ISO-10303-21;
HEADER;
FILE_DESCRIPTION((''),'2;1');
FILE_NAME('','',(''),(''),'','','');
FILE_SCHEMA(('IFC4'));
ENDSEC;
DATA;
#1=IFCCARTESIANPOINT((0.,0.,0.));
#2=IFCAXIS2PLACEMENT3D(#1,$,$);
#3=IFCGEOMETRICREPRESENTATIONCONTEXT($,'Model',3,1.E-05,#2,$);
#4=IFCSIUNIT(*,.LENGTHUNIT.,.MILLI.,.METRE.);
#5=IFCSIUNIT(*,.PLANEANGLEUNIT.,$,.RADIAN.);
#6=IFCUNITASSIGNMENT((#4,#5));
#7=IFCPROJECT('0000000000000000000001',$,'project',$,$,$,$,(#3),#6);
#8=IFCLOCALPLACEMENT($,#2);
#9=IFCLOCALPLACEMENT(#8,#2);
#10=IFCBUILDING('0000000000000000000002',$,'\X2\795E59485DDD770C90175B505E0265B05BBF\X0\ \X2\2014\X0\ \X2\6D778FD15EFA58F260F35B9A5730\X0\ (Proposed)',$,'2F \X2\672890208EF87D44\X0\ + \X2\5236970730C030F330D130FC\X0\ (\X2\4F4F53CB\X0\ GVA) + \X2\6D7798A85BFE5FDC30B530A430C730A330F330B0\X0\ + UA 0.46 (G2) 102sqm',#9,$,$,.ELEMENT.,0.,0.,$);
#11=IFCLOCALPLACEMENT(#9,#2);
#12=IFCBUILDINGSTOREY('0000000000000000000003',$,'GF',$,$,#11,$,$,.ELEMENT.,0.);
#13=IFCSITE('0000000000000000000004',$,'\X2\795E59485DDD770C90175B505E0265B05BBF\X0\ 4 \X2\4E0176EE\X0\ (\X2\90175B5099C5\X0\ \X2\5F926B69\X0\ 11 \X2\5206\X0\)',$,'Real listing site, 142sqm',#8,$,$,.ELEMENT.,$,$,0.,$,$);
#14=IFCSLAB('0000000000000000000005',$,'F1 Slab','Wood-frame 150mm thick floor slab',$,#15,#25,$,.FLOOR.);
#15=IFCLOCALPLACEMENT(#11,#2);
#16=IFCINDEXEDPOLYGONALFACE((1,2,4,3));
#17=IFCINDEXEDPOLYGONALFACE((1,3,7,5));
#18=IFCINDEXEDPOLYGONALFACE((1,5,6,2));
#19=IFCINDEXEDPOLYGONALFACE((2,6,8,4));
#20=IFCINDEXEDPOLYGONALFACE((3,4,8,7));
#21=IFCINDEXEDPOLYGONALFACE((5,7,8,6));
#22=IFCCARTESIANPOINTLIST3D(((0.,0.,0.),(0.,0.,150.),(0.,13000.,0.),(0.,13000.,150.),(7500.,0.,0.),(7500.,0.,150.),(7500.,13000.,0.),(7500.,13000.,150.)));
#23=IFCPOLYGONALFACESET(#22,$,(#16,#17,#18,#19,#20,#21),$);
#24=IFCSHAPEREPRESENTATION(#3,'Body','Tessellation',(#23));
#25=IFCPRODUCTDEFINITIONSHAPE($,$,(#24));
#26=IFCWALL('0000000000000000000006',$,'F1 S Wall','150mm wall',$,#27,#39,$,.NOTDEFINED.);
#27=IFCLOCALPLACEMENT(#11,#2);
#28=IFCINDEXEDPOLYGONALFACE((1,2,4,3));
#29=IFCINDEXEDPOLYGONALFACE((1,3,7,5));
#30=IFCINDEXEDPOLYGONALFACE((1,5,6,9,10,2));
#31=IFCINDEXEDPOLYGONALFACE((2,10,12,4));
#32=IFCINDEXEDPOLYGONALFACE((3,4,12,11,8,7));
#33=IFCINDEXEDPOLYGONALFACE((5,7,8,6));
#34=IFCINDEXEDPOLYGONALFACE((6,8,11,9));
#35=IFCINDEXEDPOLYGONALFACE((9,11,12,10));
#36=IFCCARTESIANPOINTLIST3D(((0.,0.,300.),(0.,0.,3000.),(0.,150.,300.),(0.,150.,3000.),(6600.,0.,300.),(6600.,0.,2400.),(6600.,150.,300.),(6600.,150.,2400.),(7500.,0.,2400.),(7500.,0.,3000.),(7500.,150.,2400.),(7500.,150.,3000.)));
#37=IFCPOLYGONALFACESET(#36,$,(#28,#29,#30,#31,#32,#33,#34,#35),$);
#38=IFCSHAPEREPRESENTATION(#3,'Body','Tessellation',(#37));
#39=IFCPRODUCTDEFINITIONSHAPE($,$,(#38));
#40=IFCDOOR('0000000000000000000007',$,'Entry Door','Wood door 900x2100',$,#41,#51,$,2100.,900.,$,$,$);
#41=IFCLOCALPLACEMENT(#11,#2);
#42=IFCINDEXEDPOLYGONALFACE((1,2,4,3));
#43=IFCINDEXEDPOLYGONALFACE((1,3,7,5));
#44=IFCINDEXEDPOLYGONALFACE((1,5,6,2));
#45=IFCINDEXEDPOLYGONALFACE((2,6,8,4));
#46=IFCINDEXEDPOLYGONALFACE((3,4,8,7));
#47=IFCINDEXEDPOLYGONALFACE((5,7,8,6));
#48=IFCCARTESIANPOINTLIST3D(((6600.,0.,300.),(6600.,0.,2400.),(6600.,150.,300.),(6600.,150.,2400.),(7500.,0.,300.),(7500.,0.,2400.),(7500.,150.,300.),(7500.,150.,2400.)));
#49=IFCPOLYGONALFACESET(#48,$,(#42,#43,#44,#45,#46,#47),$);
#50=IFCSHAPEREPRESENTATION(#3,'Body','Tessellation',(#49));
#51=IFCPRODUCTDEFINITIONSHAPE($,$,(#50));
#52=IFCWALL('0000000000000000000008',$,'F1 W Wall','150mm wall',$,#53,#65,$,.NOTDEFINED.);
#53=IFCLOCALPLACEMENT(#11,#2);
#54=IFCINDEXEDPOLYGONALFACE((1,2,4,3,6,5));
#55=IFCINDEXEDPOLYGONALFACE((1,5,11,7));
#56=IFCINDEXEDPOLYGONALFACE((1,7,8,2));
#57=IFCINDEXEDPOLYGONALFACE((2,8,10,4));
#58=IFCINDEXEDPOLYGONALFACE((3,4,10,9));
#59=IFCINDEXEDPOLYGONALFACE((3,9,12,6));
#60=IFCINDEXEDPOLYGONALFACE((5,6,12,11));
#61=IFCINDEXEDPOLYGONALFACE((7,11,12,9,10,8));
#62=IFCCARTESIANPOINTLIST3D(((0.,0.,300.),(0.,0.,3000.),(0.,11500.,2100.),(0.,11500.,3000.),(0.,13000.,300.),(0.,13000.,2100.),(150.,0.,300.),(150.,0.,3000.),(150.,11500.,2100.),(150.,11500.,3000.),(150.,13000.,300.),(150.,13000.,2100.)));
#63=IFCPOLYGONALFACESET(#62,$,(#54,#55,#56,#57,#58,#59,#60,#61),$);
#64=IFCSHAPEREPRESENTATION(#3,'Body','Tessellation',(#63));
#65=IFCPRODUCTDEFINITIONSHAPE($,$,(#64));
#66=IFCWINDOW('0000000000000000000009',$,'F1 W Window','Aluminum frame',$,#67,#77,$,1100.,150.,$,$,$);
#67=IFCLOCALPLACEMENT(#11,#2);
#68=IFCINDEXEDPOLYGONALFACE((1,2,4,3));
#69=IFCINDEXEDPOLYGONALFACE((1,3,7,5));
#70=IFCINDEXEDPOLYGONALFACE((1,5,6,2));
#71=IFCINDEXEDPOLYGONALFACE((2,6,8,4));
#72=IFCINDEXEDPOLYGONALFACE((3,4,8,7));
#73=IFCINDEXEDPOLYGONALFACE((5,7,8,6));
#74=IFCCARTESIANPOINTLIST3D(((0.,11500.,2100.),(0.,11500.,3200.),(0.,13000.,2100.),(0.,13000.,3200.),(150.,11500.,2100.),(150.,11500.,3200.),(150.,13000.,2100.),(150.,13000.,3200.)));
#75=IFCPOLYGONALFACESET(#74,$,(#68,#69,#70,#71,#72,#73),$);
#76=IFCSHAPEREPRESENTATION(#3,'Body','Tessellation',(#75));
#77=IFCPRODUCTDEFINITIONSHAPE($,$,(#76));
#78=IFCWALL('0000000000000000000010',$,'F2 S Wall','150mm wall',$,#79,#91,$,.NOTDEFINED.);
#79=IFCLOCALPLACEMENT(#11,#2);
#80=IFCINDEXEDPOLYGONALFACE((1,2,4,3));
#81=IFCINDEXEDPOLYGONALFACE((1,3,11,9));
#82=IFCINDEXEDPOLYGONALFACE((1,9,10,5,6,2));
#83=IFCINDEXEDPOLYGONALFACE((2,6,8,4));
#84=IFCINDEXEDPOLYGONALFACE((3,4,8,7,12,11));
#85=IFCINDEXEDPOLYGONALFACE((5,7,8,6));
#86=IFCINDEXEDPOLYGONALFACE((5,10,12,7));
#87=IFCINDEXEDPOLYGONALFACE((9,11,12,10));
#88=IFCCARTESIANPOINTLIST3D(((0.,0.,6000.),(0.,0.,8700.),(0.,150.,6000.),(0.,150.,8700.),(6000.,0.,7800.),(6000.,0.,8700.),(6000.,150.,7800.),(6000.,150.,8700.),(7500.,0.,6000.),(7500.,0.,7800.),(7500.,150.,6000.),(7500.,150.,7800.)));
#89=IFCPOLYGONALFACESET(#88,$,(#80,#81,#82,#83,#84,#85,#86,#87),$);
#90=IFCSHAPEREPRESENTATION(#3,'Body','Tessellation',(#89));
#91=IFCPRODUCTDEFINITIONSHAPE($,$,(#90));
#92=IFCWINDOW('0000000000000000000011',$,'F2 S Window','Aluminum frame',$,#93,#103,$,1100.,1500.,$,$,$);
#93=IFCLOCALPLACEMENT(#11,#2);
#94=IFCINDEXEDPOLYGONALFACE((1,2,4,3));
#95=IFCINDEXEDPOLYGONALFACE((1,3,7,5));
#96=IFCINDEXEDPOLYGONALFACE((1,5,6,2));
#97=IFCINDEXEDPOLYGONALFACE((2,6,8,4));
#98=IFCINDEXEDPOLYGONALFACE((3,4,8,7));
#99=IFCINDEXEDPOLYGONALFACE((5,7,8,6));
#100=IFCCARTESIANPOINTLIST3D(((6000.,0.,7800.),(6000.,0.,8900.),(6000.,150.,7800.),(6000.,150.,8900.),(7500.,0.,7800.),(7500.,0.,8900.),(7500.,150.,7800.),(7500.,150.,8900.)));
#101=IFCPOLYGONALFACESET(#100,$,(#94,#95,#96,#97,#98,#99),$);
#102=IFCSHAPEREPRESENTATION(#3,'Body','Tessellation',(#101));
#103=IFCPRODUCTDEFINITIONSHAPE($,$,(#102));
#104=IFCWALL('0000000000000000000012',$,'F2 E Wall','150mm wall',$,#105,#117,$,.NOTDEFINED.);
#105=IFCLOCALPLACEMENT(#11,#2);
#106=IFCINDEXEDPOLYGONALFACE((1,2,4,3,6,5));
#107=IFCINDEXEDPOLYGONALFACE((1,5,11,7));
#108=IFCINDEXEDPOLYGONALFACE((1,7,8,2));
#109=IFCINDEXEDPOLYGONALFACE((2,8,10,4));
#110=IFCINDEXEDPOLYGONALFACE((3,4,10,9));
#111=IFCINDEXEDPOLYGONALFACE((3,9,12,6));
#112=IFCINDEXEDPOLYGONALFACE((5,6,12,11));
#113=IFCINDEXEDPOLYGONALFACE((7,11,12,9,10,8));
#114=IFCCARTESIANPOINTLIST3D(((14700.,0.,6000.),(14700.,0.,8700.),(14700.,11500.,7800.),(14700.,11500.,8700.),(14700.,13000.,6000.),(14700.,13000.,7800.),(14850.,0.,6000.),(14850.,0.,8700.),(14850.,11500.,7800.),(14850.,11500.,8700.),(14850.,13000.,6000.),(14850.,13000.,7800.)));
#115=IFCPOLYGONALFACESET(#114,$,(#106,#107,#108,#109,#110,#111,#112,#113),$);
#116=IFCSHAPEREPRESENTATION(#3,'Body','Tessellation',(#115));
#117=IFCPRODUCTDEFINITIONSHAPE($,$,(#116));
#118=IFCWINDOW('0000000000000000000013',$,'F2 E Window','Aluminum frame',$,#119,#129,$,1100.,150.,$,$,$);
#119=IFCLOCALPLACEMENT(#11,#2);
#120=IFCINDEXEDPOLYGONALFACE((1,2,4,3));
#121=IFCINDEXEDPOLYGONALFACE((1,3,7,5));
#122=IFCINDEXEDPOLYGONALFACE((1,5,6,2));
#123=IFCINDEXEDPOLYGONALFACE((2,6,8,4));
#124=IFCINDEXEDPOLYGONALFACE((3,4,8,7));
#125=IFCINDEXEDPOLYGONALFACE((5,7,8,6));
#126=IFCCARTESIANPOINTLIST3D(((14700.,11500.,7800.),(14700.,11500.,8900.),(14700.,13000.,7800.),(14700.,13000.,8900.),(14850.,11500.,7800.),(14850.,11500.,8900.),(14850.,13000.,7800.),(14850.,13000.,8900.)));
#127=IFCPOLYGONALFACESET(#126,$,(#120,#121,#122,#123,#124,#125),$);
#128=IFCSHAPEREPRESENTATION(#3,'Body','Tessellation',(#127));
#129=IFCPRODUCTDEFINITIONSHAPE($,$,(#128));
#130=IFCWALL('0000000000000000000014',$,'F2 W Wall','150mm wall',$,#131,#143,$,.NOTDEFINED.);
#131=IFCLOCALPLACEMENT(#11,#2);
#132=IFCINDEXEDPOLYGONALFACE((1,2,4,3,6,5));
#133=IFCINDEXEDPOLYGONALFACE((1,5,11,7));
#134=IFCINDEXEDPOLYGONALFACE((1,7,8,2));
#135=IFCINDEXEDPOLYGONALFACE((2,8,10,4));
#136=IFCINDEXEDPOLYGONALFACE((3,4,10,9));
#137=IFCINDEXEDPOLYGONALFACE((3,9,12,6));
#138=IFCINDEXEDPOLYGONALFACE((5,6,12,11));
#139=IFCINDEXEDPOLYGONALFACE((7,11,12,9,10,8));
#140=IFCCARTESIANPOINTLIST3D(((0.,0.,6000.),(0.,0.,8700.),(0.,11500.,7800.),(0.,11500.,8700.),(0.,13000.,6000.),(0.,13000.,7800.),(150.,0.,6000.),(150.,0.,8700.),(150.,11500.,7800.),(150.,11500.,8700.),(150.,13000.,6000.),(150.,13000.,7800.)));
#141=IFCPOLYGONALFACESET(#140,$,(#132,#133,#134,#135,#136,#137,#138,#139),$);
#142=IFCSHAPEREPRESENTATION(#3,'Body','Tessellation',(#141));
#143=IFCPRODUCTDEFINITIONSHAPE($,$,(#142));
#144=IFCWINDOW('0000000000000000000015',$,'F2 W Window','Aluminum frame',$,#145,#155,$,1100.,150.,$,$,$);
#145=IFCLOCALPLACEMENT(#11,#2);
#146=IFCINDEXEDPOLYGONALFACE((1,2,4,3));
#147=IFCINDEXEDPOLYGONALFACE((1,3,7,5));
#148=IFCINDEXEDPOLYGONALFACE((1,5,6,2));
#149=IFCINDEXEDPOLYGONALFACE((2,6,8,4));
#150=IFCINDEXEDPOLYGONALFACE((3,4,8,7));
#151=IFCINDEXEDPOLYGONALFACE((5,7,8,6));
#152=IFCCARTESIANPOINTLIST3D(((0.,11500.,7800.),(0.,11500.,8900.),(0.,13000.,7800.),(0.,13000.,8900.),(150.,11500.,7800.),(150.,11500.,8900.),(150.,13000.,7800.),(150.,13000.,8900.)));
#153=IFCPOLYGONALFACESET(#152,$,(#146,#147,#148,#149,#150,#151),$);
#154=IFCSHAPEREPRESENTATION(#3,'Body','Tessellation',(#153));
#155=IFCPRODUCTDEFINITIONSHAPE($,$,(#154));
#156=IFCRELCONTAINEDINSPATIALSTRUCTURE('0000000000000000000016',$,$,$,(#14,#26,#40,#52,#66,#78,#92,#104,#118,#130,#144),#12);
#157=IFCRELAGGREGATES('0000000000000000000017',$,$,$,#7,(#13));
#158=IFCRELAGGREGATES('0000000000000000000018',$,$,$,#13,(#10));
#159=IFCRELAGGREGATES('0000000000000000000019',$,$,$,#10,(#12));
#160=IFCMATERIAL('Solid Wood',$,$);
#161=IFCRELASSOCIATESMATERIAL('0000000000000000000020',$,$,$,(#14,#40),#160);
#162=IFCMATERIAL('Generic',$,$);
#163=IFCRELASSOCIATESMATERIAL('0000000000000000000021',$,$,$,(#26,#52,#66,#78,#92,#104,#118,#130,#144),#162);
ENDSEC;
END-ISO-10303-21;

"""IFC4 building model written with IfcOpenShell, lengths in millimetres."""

from ifc_helpers import new_model, si_unit, frame, frame_2d, origin, place, context, project, spatial, rectangle, extrude, material, element, fill, save


model = new_model("IFC4")

# Units and contexts
model_context = context("Model", 3, precision=1e-05, world=origin())
ifc_project = project(units=[si_unit("LENGTHUNIT", "METRE", prefix="MILLI"), si_unit("PLANEANGLEUNIT", "RADIAN")], contexts=[model_context])

# Site, building, storey
site_placement = place(None, origin())
site = spatial("IfcSite", under=ifc_project, at=site_placement, Name="神奈川県逗子市新宿 4 丁目 (逗子駅 徒歩 11 分)", ObjectType="Real listing site, 142sqm", CompositionType="ELEMENT", RefElevation=0.0)
building_placement = place(site_placement, origin())
building = spatial("IfcBuilding", under=site, at=building_placement, Name="神奈川県逗子市新宿 — 海近建売想定地 (Proposed)", ObjectType="2F 木造軸組 + 制震ダンパー (住友 GVA) + 海風対応サイディング + UA 0.46 (G2) 102sqm", CompositionType="ELEMENT", ElevationOfRefHeight=0.0, ElevationOfTerrain=0.0)
storey_placement = place(building_placement, origin())
storey = spatial("IfcBuildingStorey", under=building, at=storey_placement, Name="GF", CompositionType="ELEMENT", Elevation=0.0)

# Slab
ifc_material_1 = material(Name="Solid Wood")
slab_1_placement = place(storey_placement, origin())
element("IfcSlab", 1, at=slab_1_placement, inside=storey, material=ifc_material_1, Name="F1 Slab", Description="Wood-frame 150mm thick floor slab", PredefinedType="FLOOR", context=model_context, shape_type="SweptSolid", body=[
    extrude(rectangle(XDim=7500.0, YDim=13000.0, at=frame_2d((3750.0, 6500.0))), origin(), (0.0, 0.0, 1.0), 150.0),
])

# Shared definitions
ifc_material_2 = material(Name="Generic")

# Wall, opening, door
wall_1_placement = place(storey_placement, frame((0.0, 0.0, 150.0)))
wall_1 = element("IfcWall", 2, at=wall_1_placement, inside=storey, material=ifc_material_2, Name="F1 S Wall", Description="150mm wall", PredefinedType="NOTDEFINED", context=model_context, shape_type="SweptSolid", body=[
    extrude(rectangle(XDim=7500.0, YDim=150.0, at=frame_2d((3750.0, 75.0))), frame((0.0, 0.0, 150.0)), (0.0, 0.0, 1.0), 2700.0),
])
opening_1_placement = place(storey_placement, frame((3300.0, 0.0, 150.0)))
opening_1 = element("IfcOpeningElement", 3, at=opening_1_placement, cuts=wall_1, PredefinedType="NOTDEFINED", context=model_context, shape_type="SweptSolid", body=[
    extrude(rectangle(XDim=900.0, YDim=150.0, at=frame_2d((450.0, 75.0))), frame((3300.0, 0.0, 150.0)), (0.0, 0.0, 1.0), 2100.0),
])
door_placement = place(storey_placement, frame((3300.0, 0.0, 150.0)))
door = element("IfcDoor", 4, at=door_placement, inside=storey, material=ifc_material_1, Name="Entry Door", Description="Wood door 900x2100", OverallHeight=2100.0, OverallWidth=900.0, context=model_context, shape_type="SweptSolid", body=[
    extrude(rectangle(XDim=900.0, YDim=150.0, at=frame_2d((450.0, 75.0))), frame((3300.0, 0.0, 150.0)), (0.0, 0.0, 1.0), 2100.0),
])
fill(opening_1, door)

# Walls, openings, windows
wall_2_placement = place(storey_placement, frame((0.0, 0.0, 150.0)))
wall_2 = element("IfcWall", 5, at=wall_2_placement, inside=storey, material=ifc_material_2, Name="F1 W Wall", Description="150mm wall", PredefinedType="NOTDEFINED", context=model_context, shape_type="SweptSolid", body=[
    extrude(rectangle(XDim=150.0, YDim=13000.0, at=frame_2d((75.0, 6500.0))), frame((0.0, 0.0, 150.0)), (0.0, 0.0, 1.0), 2700.0),
])
opening_2_placement = place(storey_placement, frame((0.0, 5750.0, 1050.0)))
opening_2 = element("IfcOpeningElement", 6, at=opening_2_placement, cuts=wall_2, PredefinedType="NOTDEFINED", context=model_context, shape_type="SweptSolid", body=[
    extrude(rectangle(XDim=150.0, YDim=1500.0, at=frame_2d((75.0, 750.0))), frame((0.0, 5750.0, 1050.0)), (0.0, 0.0, 1.0), 1100.0),
])
window_1_placement = place(storey_placement, frame((0.0, 5750.0, 1050.0)))
window_1 = element("IfcWindow", 7, at=window_1_placement, inside=storey, material=ifc_material_2, Name="F1 W Window", Description="Aluminum frame", OverallHeight=1100.0, OverallWidth=150.0, context=model_context, shape_type="SweptSolid", body=[
    extrude(rectangle(XDim=150.0, YDim=1500.0, at=frame_2d((75.0, 750.0))), frame((0.0, 5750.0, 1050.0)), (0.0, 0.0, 1.0), 1100.0),
])
fill(opening_2, window_1)
wall_3_placement = place(storey_placement, frame((0.0, 0.0, 3000.0)))
wall_3 = element("IfcWall", 8, at=wall_3_placement, inside=storey, material=ifc_material_2, Name="F2 S Wall", Description="150mm wall", PredefinedType="NOTDEFINED", context=model_context, shape_type="SweptSolid", body=[
    extrude(rectangle(XDim=7500.0, YDim=150.0, at=frame_2d((3750.0, 75.0))), frame((0.0, 0.0, 3000.0)), (0.0, 0.0, 1.0), 2700.0),
])
opening_3_placement = place(storey_placement, frame((3000.0, 0.0, 3900.0)))
opening_3 = element("IfcOpeningElement", 9, at=opening_3_placement, cuts=wall_3, PredefinedType="NOTDEFINED", context=model_context, shape_type="SweptSolid", body=[
    extrude(rectangle(XDim=1500.0, YDim=150.0, at=frame_2d((750.0, 75.0))), frame((3000.0, 0.0, 3900.0)), (0.0, 0.0, 1.0), 1100.0),
])
window_2_placement = place(storey_placement, frame((3000.0, 0.0, 3900.0)))
window_2 = element("IfcWindow", 10, at=window_2_placement, inside=storey, material=ifc_material_2, Name="F2 S Window", Description="Aluminum frame", OverallHeight=1100.0, OverallWidth=1500.0, context=model_context, shape_type="SweptSolid", body=[
    extrude(rectangle(XDim=1500.0, YDim=150.0, at=frame_2d((750.0, 75.0))), frame((3000.0, 0.0, 3900.0)), (0.0, 0.0, 1.0), 1100.0),
])
fill(opening_3, window_2)
wall_4_placement = place(storey_placement, frame((7350.0, 0.0, 3000.0)))
wall_4 = element("IfcWall", 11, at=wall_4_placement, inside=storey, material=ifc_material_2, Name="F2 E Wall", Description="150mm wall", PredefinedType="NOTDEFINED", context=model_context, shape_type="SweptSolid", body=[
    extrude(rectangle(XDim=150.0, YDim=13000.0, at=frame_2d((75.0, 6500.0))), frame((7350.0, 0.0, 3000.0)), (0.0, 0.0, 1.0), 2700.0),
])
opening_4_placement = place(storey_placement, frame((7350.0, 5750.0, 3900.0)))
opening_4 = element("IfcOpeningElement", 12, at=opening_4_placement, cuts=wall_4, PredefinedType="NOTDEFINED", context=model_context, shape_type="SweptSolid", body=[
    extrude(rectangle(XDim=150.0, YDim=1500.0, at=frame_2d((75.0, 750.0))), frame((7350.0, 5750.0, 3900.0)), (0.0, 0.0, 1.0), 1100.0),
])
window_3_placement = place(storey_placement, frame((7350.0, 5750.0, 3900.0)))
window_3 = element("IfcWindow", 13, at=window_3_placement, inside=storey, material=ifc_material_2, Name="F2 E Window", Description="Aluminum frame", OverallHeight=1100.0, OverallWidth=150.0, context=model_context, shape_type="SweptSolid", body=[
    extrude(rectangle(XDim=150.0, YDim=1500.0, at=frame_2d((75.0, 750.0))), frame((7350.0, 5750.0, 3900.0)), (0.0, 0.0, 1.0), 1100.0),
])
fill(opening_4, window_3)
wall_5_placement = place(storey_placement, frame((0.0, 0.0, 3000.0)))
wall_5 = element("IfcWall", 14, at=wall_5_placement, inside=storey, material=ifc_material_2, Name="F2 W Wall", Description="150mm wall", PredefinedType="NOTDEFINED", context=model_context, shape_type="SweptSolid", body=[
    extrude(rectangle(XDim=150.0, YDim=13000.0, at=frame_2d((75.0, 6500.0))), frame((0.0, 0.0, 3000.0)), (0.0, 0.0, 1.0), 2700.0),
])
opening_5_placement = place(storey_placement, frame((0.0, 5750.0, 3900.0)))
opening_5 = element("IfcOpeningElement", 15, at=opening_5_placement, cuts=wall_5, PredefinedType="NOTDEFINED", context=model_context, shape_type="SweptSolid", body=[
    extrude(rectangle(XDim=150.0, YDim=1500.0, at=frame_2d((75.0, 750.0))), frame((0.0, 5750.0, 3900.0)), (0.0, 0.0, 1.0), 1100.0),
])
window_4_placement = place(storey_placement, frame((0.0, 5750.0, 3900.0)))
window_4 = element("IfcWindow", 16, at=window_4_placement, inside=storey, material=ifc_material_2, Name="F2 W Window", Description="Aluminum frame", OverallHeight=1100.0, OverallWidth=150.0, context=model_context, shape_type="SweptSolid", body=[
    extrude(rectangle(XDim=150.0, YDim=1500.0, at=frame_2d((75.0, 750.0))), frame((0.0, 5750.0, 3900.0)), (0.0, 0.0, 1.0), 1100.0),
])
fill(opening_5, window_4)

save(model, "model.ifc")
